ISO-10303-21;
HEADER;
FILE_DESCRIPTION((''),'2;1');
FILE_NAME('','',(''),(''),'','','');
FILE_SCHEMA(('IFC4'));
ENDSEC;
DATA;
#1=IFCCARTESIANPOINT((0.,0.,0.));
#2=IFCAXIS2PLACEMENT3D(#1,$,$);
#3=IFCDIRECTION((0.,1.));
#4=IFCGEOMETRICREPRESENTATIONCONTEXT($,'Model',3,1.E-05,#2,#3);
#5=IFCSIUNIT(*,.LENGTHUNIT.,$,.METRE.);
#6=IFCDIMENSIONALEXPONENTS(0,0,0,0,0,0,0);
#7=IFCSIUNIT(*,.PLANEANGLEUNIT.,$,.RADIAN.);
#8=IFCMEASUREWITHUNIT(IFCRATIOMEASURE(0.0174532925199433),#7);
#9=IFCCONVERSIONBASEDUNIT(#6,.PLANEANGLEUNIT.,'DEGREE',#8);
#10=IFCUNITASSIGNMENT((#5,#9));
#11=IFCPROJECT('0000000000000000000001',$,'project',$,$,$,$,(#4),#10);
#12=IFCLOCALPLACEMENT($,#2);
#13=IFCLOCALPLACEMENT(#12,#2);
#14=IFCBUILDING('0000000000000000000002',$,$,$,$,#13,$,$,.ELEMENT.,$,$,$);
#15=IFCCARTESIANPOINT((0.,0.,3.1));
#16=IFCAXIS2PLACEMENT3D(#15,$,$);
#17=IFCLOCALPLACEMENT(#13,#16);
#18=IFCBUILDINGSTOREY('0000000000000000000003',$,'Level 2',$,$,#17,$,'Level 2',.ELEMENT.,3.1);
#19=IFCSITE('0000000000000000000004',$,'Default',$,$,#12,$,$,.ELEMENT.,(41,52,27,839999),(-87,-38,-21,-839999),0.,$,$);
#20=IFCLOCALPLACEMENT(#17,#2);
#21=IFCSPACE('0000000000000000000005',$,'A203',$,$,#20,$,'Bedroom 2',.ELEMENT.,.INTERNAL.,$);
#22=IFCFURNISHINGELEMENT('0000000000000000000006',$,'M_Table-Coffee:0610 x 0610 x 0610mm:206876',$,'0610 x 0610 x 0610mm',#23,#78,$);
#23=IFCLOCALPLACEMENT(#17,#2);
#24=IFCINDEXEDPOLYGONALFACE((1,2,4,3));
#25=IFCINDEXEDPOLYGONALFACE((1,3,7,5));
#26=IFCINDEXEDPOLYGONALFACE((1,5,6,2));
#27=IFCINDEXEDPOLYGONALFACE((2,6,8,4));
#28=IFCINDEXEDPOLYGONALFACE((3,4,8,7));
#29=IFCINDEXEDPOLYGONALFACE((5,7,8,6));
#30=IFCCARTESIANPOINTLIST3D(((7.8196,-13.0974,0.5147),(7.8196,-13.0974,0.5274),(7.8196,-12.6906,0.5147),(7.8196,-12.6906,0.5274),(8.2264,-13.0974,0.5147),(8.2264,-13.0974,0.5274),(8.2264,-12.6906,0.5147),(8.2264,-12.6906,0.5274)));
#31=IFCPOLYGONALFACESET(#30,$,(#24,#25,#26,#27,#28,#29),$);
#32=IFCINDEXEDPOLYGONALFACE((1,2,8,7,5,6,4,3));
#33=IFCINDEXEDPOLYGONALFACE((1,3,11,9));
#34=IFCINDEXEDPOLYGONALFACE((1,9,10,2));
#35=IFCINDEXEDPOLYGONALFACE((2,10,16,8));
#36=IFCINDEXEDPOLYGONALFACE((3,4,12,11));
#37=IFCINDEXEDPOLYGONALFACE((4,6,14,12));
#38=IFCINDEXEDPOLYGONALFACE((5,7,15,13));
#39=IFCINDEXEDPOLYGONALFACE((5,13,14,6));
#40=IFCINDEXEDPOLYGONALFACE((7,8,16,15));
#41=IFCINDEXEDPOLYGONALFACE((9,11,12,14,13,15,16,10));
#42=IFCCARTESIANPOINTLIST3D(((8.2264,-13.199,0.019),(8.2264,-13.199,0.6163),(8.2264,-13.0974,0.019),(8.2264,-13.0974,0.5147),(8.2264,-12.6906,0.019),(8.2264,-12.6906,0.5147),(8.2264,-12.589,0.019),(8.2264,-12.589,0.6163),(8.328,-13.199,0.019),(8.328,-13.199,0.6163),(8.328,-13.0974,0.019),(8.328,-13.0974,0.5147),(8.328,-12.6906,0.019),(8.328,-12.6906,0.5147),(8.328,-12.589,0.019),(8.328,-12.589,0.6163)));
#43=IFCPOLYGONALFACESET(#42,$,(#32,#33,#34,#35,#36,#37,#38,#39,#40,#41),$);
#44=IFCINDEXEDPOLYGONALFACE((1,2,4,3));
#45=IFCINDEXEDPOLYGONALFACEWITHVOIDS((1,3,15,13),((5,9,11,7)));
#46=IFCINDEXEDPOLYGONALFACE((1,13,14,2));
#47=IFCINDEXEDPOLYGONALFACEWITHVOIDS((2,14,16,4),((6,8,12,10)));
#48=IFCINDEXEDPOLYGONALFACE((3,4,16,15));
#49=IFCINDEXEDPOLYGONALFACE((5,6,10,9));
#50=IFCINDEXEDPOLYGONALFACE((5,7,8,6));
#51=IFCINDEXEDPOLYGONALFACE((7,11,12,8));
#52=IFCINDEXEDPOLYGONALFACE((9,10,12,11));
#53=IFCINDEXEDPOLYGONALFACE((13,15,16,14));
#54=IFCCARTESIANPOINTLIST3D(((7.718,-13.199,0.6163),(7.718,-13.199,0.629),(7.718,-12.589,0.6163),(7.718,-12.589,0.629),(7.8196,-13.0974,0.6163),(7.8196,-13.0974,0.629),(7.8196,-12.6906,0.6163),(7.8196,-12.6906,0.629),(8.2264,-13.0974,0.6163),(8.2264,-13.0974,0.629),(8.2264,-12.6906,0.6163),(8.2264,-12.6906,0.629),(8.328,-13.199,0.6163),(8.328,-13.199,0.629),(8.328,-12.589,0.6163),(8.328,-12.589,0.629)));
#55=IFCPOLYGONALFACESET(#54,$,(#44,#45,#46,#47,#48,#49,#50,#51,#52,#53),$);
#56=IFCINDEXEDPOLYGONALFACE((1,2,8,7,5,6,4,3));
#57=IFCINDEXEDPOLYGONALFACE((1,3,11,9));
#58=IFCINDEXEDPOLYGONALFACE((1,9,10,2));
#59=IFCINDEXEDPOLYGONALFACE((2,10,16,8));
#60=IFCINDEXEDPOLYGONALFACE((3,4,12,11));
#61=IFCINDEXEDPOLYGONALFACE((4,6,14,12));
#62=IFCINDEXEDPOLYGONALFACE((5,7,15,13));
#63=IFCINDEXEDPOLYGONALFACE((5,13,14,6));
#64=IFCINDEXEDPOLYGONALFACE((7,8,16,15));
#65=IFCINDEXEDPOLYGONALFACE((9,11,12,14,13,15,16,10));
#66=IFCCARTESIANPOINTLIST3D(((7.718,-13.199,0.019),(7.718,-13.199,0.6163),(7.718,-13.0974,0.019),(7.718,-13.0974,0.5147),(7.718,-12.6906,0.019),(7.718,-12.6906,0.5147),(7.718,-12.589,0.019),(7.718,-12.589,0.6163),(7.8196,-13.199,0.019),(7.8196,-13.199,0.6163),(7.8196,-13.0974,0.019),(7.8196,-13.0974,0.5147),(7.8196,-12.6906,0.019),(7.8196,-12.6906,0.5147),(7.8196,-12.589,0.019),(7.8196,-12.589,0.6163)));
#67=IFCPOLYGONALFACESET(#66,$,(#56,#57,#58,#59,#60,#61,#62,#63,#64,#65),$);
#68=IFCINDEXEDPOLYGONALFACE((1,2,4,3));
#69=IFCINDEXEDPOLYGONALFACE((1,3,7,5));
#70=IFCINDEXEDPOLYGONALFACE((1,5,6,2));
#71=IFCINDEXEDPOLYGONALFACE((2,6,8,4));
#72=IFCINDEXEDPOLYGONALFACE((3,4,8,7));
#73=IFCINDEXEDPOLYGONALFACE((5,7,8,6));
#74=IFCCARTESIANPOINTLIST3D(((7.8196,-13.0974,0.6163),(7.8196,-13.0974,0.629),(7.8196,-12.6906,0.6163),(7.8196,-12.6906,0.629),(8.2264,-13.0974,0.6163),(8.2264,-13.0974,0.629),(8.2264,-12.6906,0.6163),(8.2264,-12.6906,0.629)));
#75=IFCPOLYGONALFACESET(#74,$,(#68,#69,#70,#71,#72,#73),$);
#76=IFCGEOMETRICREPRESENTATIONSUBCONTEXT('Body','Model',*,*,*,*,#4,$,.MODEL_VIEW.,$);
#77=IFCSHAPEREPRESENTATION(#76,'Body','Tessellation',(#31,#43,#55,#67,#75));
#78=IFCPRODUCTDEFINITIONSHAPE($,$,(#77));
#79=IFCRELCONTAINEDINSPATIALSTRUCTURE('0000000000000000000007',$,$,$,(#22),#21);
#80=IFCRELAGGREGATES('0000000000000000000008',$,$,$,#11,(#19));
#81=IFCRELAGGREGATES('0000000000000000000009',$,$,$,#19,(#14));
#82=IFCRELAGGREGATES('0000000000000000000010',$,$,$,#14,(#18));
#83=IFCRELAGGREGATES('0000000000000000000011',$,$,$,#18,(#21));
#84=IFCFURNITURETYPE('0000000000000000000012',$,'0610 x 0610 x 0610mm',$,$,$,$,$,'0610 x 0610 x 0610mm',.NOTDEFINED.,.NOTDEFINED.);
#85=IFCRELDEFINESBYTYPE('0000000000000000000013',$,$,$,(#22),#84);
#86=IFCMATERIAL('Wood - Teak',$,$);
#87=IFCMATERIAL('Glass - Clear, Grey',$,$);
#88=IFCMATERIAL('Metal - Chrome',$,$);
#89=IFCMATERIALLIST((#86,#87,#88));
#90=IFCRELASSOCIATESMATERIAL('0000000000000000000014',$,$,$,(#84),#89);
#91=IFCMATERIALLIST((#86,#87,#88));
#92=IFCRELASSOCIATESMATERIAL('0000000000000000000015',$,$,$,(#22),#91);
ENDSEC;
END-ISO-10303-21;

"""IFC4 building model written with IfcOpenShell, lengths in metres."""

from ifc_helpers import new_model, entity, si_unit, converted_unit, direction, frame, origin, origin_2d_with_axis, place, context, subcontext, project, spatial, polyline, rectangle, outline, extrude, source, transform, mapped, material, material_list, type_object, type_shapes, element, save


model = new_model("IFC4")

# Units and contexts
model_context = context("Model", 3, precision=1e-05, world=origin(), true_north=direction((0.0, 1.0)))
body_context = subcontext(model_context, "Body", "Model", "MODEL_VIEW")
ifc_project = project(units=[si_unit("LENGTHUNIT", "METRE"), converted_unit("PLANEANGLEUNIT", "DEGREE", entity("IfcRatioMeasure", 0.0174532925199433), si_unit("PLANEANGLEUNIT", "RADIAN"), dimensions=[0, 0, 0, 0, 0, 0, 0])], contexts=[model_context])

# Site, building, storey
site_placement = place(None, origin())
site = spatial("IfcSite", under=ifc_project, at=site_placement, Name="Default", CompositionType="ELEMENT", RefLatitude=(41, 52, 27, 839999), RefLongitude=(-87, -38, -21, -839999), RefElevation=0.0)
building_placement = place(site_placement, origin())
building = spatial("IfcBuilding", under=site, at=building_placement, CompositionType="ELEMENT")
storey_placement = place(building_placement, frame((0.0, 0.0, 3.1)))
storey = spatial("IfcBuildingStorey", under=building, at=storey_placement, Name="Level 2", LongName="Level 2", CompositionType="ELEMENT", Elevation=3.1)

# Shared definitions
space_1_placement = place(storey_placement, origin())
space_1 = spatial("IfcSpace", under=storey, at=space_1_placement, Name="A203", LongName="Bedroom 2", CompositionType="ELEMENT", PredefinedType="INTERNAL")

# Furnishing element
ifc_material_1 = material(Name="Wood - Teak")
ifc_material_2 = material(Name="Glass - Clear, Grey")
ifc_material_3 = material(Name="Metal - Chrome")
ifc_material_list_1 = material_list([ifc_material_1, ifc_material_2, ifc_material_3])
ifc_material_list_2 = material_list([ifc_material_1, ifc_material_2, ifc_material_3])
furniture_type_1 = type_object("IfcFurnitureType", Name="0610 x 0610 x 0610mm", ElementType="0610 x 0610 x 0610mm", AssemblyPlace="NOTDEFINED", material=ifc_material_list_2)
shared_shape_1 = source(origin(), body_context, "Body", "SweptSolid", [
    extrude(rectangle(XDim=0.4068, YDim=0.4068, at=origin_2d_with_axis()), frame((0.0183, 0.0952, 0.4957), z_axis=(0.0, 0.0, 1.0), x_axis=(-1.0, 0.0, 0.0)), (0.0, 0.0, 1.0), 0.0127),
    extrude(outline(polyline([(-0.2732, -0.305), (0.324, -0.305), (0.324, 0.305), (-0.2732, 0.305), (-0.2732, 0.2034), (0.2225, 0.2034), (0.2225, -0.2034), (-0.2732, -0.2034), (-0.2732, -0.305)])), frame((0.2217, 0.0952, 0.2732), z_axis=(1.0, 0.0, 0.0), x_axis=(0.0, 0.0, 1.0)), (0.0, 0.0, 1.0), 0.1016),
    extrude(outline(polyline([(-0.305, -0.305), (0.305, -0.305), (0.305, 0.305), (-0.305, 0.305), (-0.305, -0.305)]), holes=[polyline([(-0.2034, -0.2034), (-0.2034, 0.2034), (0.2034, 0.2034), (0.2034, -0.2034), (-0.2034, -0.2034)])]), frame((0.0183, 0.0952, 0.5973), z_axis=(0.0, 0.0, 1.0), x_axis=(-1.0, 0.0, 0.0)), (0.0, 0.0, 1.0), 0.0127),
    extrude(outline(polyline([(-0.305, -0.3241), (0.305, -0.3241), (0.305, 0.2733), (0.2034, 0.2733), (0.2034, -0.2224), (-0.2034, -0.2224), (-0.2034, 0.2733), (-0.305, 0.2733), (-0.305, -0.3241)])), frame((-0.2867, 0.0952, 0.2733), z_axis=(1.0, 0.0, 0.0), x_axis=(0.0, -1.0, 0.0)), (0.0, 0.0, 1.0), 0.1016),
    extrude(rectangle(XDim=0.4068, YDim=0.4068, at=origin_2d_with_axis()), frame((0.0183, 0.0952, 0.5973), z_axis=(0.0, 0.0, 1.0), x_axis=(-1.0, 0.0, 0.0)), (0.0, 0.0, 1.0), 0.0127),
])
type_shapes(furniture_type_1, [shared_shape_1])
furnishing_1_placement = place(space_1_placement, frame((8.0047, -12.9892, 0.019)))
element("IfcFurnishingElement", 1, at=furnishing_1_placement, inside=space_1, type_object=furniture_type_1, material=ifc_material_list_1, Name="M_Table-Coffee:0610 x 0610 x 0610mm:206876", ObjectType="0610 x 0610 x 0610mm", context=body_context, shape_type="MappedRepresentation", body=[
    mapped(shared_shape_1, transform((0.0, 0.0, 0.0), scale=1.0)),
])

save(model, "model.ifc")
